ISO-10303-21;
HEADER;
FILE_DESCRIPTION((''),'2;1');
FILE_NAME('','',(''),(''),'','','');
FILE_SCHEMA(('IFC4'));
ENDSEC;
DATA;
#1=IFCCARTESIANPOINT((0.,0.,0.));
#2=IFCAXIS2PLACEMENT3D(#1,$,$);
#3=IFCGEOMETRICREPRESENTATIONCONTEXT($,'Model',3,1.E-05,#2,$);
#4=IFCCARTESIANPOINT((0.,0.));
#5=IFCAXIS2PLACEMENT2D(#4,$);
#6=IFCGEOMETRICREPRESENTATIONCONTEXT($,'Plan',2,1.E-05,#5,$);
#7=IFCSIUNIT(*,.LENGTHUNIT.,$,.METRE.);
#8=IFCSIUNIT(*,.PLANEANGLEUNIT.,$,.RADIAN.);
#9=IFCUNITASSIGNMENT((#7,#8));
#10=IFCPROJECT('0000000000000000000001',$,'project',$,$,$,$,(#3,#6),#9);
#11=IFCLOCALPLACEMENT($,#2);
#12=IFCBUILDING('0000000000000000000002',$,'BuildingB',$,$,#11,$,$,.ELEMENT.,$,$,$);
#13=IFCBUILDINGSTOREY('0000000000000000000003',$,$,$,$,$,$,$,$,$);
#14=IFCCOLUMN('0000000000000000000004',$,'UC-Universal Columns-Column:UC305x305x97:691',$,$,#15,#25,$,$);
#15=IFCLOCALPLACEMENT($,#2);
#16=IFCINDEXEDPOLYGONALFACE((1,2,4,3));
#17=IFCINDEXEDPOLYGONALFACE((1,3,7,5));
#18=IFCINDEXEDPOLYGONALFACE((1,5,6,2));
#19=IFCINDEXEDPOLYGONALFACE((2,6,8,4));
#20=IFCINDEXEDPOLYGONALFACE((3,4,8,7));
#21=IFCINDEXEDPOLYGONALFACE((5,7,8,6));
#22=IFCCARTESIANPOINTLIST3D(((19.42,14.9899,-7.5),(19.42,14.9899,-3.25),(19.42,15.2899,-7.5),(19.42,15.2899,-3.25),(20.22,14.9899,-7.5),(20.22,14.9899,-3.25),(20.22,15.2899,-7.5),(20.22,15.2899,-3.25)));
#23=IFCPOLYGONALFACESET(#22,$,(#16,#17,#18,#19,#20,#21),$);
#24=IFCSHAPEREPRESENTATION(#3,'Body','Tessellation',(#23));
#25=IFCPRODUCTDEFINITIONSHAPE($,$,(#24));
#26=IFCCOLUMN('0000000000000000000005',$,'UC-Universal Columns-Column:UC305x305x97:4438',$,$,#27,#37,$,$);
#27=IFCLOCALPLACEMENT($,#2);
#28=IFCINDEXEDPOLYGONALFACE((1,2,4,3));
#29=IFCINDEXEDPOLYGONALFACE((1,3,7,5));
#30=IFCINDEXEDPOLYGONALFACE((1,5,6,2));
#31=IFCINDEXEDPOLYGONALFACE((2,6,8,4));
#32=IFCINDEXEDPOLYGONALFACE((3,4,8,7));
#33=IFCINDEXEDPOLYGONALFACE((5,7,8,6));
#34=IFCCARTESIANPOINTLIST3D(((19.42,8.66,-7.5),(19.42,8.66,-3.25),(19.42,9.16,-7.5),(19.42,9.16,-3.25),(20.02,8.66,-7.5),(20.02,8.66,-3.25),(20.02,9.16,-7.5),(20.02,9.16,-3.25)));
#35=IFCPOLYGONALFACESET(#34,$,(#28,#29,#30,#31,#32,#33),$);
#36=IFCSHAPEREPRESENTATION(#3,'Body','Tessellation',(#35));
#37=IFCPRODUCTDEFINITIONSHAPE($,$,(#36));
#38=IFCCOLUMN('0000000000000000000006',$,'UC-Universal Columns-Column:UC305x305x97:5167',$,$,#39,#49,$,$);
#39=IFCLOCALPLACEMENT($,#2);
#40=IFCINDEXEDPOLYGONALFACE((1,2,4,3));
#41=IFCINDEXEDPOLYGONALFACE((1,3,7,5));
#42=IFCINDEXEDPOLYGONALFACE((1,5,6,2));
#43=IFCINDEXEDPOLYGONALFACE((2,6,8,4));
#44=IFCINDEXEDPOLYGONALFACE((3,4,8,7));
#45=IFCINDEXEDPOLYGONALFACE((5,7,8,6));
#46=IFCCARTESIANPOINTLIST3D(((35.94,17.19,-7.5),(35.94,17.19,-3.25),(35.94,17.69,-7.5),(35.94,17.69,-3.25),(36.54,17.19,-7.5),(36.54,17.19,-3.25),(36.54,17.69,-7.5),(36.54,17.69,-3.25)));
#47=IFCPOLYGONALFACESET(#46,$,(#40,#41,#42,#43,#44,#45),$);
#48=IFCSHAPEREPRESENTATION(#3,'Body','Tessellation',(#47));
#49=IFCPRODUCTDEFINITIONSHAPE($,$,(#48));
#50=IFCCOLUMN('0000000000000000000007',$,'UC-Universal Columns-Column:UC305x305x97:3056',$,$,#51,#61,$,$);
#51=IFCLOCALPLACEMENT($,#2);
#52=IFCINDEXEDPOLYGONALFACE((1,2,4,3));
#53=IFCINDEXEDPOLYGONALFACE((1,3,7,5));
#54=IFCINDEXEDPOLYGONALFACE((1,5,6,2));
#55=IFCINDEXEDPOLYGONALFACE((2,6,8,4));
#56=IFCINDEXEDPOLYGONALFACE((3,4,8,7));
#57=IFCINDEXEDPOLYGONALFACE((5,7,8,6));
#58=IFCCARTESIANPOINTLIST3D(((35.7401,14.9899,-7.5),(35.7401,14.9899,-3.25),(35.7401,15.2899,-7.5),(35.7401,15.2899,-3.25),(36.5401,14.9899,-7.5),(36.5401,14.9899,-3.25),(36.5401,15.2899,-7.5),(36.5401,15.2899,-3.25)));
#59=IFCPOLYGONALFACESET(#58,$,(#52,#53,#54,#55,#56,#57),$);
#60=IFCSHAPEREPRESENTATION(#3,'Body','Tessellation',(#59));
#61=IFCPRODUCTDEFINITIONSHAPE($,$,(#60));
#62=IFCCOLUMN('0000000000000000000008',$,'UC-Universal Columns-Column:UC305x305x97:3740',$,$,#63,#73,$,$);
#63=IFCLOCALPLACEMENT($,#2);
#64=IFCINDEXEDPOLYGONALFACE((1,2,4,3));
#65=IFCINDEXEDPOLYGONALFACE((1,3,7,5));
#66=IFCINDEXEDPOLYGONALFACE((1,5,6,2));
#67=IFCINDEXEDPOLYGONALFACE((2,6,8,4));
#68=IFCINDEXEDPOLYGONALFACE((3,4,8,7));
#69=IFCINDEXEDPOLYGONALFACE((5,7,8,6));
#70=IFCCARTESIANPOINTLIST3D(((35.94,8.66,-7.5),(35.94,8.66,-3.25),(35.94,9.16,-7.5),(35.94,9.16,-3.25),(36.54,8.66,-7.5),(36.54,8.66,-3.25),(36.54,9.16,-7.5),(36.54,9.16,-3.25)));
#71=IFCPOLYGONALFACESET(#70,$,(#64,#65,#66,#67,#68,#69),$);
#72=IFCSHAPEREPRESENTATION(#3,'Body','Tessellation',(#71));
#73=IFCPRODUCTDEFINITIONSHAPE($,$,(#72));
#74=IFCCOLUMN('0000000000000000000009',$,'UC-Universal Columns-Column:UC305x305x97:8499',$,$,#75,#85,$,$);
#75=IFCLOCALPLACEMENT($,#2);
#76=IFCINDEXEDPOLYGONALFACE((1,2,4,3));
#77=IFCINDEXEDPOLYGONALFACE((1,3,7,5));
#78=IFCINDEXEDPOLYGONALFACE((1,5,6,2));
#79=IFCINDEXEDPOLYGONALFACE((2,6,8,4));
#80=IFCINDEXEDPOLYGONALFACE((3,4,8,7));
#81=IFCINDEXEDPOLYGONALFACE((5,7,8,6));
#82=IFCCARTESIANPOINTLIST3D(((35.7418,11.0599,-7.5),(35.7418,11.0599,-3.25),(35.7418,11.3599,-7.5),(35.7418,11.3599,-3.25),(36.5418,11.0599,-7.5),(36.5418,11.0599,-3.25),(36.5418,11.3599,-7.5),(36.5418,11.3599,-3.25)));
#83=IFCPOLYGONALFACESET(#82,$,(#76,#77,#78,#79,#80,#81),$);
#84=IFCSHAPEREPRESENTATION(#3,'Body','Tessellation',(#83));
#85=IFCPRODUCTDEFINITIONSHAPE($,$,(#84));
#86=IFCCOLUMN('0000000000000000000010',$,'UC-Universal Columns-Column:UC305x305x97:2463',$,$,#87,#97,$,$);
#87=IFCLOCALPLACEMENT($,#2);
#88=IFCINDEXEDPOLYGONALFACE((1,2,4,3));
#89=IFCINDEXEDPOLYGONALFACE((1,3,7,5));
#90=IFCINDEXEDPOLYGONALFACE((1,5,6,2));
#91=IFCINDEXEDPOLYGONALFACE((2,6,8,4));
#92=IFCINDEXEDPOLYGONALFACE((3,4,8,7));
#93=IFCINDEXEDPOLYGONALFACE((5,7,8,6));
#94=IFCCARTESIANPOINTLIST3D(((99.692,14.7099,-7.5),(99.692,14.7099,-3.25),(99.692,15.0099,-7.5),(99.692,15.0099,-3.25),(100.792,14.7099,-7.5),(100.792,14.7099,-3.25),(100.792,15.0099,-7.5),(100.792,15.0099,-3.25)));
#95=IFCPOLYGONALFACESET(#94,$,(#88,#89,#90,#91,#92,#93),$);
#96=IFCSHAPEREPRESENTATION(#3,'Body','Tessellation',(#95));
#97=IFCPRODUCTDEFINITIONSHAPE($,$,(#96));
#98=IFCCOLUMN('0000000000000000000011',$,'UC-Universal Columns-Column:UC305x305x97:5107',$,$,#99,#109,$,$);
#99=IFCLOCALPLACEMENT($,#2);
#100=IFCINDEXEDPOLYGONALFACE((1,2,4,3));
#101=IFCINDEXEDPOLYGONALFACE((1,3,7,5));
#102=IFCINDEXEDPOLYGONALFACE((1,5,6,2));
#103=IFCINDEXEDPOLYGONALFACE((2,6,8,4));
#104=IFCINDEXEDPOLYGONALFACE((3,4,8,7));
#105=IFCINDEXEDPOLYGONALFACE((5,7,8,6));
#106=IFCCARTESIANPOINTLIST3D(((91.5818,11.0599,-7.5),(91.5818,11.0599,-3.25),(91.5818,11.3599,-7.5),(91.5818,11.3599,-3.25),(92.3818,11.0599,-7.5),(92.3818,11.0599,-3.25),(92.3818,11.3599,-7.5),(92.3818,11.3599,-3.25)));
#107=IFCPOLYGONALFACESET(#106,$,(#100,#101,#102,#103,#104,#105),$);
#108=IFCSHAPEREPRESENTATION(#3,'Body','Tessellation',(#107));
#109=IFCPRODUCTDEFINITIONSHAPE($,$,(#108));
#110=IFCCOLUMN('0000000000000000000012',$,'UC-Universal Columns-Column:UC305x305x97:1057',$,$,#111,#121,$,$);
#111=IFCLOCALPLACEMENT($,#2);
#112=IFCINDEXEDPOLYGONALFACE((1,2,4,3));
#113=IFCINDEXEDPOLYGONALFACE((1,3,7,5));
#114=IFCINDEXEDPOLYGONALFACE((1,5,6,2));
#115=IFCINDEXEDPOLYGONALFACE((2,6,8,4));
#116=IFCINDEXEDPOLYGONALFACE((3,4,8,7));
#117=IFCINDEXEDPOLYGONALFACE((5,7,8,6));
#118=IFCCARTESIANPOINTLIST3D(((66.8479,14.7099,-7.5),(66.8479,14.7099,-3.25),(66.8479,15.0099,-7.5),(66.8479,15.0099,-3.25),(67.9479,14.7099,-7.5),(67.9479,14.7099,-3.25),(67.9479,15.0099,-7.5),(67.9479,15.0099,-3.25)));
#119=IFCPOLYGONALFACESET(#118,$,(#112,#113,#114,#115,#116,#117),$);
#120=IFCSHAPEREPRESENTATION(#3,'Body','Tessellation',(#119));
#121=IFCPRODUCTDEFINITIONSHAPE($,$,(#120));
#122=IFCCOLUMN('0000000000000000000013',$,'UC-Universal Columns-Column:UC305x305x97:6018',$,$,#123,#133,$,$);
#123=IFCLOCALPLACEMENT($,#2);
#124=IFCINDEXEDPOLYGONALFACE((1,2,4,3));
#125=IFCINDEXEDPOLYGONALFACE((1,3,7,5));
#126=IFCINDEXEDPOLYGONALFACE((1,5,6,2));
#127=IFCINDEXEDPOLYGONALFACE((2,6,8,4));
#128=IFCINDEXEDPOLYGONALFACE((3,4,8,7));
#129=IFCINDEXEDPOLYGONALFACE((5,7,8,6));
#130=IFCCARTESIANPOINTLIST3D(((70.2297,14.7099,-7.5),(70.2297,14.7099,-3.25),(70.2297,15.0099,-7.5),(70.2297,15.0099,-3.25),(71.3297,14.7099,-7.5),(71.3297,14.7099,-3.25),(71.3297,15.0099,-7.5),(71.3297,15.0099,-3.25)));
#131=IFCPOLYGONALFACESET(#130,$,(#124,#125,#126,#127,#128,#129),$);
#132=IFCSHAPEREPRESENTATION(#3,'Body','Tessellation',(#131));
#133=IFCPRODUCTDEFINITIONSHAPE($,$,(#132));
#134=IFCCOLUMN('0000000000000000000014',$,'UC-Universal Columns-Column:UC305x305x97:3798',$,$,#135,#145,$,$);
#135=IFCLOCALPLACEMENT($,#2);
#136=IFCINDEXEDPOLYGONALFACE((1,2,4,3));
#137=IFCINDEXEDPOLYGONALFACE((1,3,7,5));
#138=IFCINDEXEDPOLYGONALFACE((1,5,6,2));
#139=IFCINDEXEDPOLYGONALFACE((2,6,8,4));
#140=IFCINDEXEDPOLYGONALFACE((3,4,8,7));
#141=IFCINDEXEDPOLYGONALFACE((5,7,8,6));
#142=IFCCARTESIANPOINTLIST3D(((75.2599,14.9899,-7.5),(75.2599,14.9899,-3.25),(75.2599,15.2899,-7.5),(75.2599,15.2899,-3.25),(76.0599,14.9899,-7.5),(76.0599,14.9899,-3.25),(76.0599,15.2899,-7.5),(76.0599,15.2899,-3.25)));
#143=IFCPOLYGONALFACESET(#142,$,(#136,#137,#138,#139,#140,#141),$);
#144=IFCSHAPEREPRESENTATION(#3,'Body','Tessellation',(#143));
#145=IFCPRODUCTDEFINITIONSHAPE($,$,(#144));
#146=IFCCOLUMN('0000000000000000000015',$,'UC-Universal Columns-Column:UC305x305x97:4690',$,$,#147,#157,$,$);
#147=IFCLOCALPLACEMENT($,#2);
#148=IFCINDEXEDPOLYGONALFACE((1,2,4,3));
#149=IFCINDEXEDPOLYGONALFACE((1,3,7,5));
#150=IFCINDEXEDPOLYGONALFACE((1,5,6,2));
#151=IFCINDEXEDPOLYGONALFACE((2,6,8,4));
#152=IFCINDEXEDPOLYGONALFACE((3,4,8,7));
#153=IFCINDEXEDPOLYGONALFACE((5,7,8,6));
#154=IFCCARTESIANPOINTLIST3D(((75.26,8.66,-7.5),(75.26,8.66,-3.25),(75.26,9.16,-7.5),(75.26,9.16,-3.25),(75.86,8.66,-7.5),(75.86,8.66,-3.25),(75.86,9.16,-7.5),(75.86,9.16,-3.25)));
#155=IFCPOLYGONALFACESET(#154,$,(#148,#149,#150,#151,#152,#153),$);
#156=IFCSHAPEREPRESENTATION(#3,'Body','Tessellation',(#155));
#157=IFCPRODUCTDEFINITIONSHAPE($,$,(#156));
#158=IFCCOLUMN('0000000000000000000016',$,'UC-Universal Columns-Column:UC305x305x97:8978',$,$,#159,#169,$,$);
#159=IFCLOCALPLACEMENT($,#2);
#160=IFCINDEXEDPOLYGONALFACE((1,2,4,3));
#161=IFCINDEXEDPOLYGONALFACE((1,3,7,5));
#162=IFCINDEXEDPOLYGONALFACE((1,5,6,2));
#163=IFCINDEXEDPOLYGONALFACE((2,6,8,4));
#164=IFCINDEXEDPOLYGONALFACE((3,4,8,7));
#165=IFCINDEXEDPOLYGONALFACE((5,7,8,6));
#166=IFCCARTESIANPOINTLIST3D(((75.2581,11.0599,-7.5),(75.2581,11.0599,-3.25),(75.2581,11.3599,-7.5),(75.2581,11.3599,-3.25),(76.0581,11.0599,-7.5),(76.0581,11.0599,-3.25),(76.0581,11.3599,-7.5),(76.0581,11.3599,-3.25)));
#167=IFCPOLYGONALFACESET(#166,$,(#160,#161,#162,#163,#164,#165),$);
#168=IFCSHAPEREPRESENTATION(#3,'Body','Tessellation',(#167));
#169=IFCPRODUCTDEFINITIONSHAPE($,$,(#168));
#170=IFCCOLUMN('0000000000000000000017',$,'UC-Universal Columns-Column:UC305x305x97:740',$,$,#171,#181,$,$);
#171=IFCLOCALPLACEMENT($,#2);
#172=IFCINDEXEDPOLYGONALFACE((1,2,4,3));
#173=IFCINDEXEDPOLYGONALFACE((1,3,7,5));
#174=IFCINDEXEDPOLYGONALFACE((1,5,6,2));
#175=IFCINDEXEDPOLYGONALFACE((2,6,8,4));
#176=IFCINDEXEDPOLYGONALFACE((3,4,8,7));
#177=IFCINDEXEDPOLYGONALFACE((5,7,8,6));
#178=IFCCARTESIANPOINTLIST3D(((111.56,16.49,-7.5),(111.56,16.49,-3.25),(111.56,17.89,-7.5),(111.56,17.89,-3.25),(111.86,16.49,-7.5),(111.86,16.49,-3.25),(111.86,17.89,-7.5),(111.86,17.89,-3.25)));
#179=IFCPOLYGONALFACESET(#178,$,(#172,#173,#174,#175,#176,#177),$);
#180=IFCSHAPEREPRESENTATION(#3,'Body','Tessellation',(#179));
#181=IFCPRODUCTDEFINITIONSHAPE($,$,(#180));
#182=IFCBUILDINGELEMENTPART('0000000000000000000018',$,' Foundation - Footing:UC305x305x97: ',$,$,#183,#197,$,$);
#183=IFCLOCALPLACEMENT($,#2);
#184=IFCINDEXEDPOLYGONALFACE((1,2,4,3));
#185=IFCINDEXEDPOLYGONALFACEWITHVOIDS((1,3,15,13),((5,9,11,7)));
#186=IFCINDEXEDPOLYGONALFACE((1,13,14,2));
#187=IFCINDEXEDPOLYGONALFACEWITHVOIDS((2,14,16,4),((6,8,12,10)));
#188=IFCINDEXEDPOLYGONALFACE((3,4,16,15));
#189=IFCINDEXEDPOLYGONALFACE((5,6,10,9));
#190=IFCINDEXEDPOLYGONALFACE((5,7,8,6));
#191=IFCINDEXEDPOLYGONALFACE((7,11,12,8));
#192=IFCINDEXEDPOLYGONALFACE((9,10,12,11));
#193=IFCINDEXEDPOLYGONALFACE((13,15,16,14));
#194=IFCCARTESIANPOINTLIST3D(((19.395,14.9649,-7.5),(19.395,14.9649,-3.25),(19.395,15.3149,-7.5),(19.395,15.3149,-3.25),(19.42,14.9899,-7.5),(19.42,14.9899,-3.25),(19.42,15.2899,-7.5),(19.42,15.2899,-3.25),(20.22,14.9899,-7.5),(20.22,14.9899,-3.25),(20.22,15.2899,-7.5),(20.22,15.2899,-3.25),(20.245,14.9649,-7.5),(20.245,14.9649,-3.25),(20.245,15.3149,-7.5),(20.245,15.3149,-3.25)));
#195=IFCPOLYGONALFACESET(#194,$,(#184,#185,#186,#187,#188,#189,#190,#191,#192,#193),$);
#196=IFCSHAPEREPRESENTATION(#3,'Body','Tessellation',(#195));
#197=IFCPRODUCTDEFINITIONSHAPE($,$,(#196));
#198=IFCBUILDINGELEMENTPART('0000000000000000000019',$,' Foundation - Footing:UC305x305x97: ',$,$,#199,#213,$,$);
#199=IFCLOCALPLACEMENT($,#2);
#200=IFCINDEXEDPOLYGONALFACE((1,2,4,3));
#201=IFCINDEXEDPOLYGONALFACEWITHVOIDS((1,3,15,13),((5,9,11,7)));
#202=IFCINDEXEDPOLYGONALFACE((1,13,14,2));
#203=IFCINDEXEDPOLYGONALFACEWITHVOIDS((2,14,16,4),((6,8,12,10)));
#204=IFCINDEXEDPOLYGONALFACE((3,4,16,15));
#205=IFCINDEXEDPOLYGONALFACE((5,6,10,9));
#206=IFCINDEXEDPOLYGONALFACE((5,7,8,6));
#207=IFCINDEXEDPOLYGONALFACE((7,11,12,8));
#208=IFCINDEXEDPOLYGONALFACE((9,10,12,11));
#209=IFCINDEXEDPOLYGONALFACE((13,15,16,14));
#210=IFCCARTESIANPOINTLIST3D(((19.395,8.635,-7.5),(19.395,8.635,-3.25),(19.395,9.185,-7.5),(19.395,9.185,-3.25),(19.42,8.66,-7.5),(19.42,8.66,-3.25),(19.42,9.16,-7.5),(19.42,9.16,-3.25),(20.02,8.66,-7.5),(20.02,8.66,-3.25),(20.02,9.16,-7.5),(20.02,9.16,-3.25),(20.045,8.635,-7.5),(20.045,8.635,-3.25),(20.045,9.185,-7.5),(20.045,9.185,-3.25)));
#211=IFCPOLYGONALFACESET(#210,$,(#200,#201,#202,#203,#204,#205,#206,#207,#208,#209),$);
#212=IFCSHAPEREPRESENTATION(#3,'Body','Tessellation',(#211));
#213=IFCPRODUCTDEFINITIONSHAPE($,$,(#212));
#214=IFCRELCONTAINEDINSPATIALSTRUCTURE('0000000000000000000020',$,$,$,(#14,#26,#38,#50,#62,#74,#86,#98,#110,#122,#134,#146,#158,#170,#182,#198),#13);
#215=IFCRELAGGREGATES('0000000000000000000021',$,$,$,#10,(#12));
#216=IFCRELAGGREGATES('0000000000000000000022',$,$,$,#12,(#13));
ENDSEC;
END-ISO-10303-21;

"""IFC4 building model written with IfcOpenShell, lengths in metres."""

from ifc_helpers import new_model, si_unit, origin, origin_2d, place, context, project, spatial, polyline, outline, extrude, element, save


model = new_model("IFC4")

# Units and contexts
model_context = context("Model", 3, precision=1e-05, world=origin())
plan_context = context("Plan", 2, precision=1e-05, world=origin_2d())
ifc_project = project(units=[si_unit("LENGTHUNIT", "METRE"), si_unit("PLANEANGLEUNIT", "RADIAN")], contexts=[model_context, plan_context])

# Building, storey
building_placement = place(None, origin())
building = spatial("IfcBuilding", under=ifc_project, at=building_placement, Name="BuildingB", CompositionType="ELEMENT")
storey = spatial("IfcBuildingStorey", under=building)

# Columns
element("IfcColumn", 1, inside=storey, Name="UC-Universal Columns-Column:UC305x305x97:691", context=model_context, shape_type="SweptSolid", body=[
    extrude(outline(polyline([(19.42, 15.2899, -7.5), (20.22, 15.2899, -7.5), (20.22, 14.9899, -7.5), (19.42, 14.9899, -7.5), (19.42, 15.2899, -7.5)])), None, (0.0, 0.0, 1.0), 4.25),
])
element("IfcColumn", 2, inside=storey, Name="UC-Universal Columns-Column:UC305x305x97:4438", context=model_context, shape_type="SweptSolid", body=[
    extrude(outline(polyline([(19.42, 8.66, -7.5), (20.02, 8.66, -7.5), (20.02, 9.16, -7.5), (19.42, 9.16, -7.5), (19.42, 8.66, -7.5)])), None, (0.0, 0.0, 1.0), 4.25),
])
element("IfcColumn", 3, inside=storey, Name="UC-Universal Columns-Column:UC305x305x97:5167", context=model_context, shape_type="SweptSolid", body=[
    extrude(outline(polyline([(36.54, 17.69, -7.5), (35.94, 17.69, -7.5), (35.94, 17.19, -7.5), (36.54, 17.19, -7.5), (36.54, 17.69, -7.5)])), None, (0.0, 0.0, 1.0), 4.25),
])
element("IfcColumn", 4, inside=storey, Name="UC-Universal Columns-Column:UC305x305x97:3056", context=model_context, shape_type="SweptSolid", body=[
    extrude(outline(polyline([(36.5401, 15.2899, -7.5), (35.7401, 15.2899, -7.5), (35.7401, 14.9899, -7.5), (36.5401, 14.9899, -7.5), (36.5401, 15.2899, -7.5)])), None, (0.0, 0.0, 1.0), 4.25),
])
element("IfcColumn", 5, inside=storey, Name="UC-Universal Columns-Column:UC305x305x97:3740", context=model_context, shape_type="SweptSolid", body=[
    extrude(outline(polyline([(36.54, 8.66, -7.5), (35.94, 8.66, -7.5), (35.94, 9.16, -7.5), (36.54, 9.16, -7.5), (36.54, 8.66, -7.5)])), None, (0.0, 0.0, 1.0), 4.25),
])
element("IfcColumn", 6, inside=storey, Name="UC-Universal Columns-Column:UC305x305x97:8499", context=model_context, shape_type="SweptSolid", body=[
    extrude(outline(polyline([(36.5418, 11.0599, -7.5), (35.7418, 11.0599, -7.5), (35.7418, 11.3599, -7.5), (36.5418, 11.3599, -7.5), (36.5418, 11.0599, -7.5)])), None, (0.0, 0.0, 1.0), 4.25),
])
element("IfcColumn", 7, inside=storey, Name="UC-Universal Columns-Column:UC305x305x97:2463", context=model_context, shape_type="SweptSolid", body=[
    extrude(outline(polyline([(100.792, 14.7099, -7.5), (100.792, 15.0099, -7.5), (99.692, 15.0099, -7.5), (99.692, 14.7099, -7.5), (100.792, 14.7099, -7.5)])), None, (0.0, 0.0, 1.0), 4.25),
])
element("IfcColumn", 8, inside=storey, Name="UC-Universal Columns-Column:UC305x305x97:5107", context=model_context, shape_type="SweptSolid", body=[
    extrude(outline(polyline([(92.3818, 11.0599, -7.5), (91.5818, 11.0599, -7.5), (91.5818, 11.3599, -7.5), (92.3818, 11.3599, -7.5), (92.3818, 11.0599, -7.5)])), None, (0.0, 0.0, 1.0), 4.25),
])
element("IfcColumn", 9, inside=storey, Name="UC-Universal Columns-Column:UC305x305x97:1057", context=model_context, shape_type="SweptSolid", body=[
    extrude(outline(polyline([(66.8479, 14.7099, -7.5), (66.8479, 15.0099, -7.5), (67.9479, 15.0099, -7.5), (67.9479, 14.7099, -7.5), (66.8479, 14.7099, -7.5)])), None, (0.0, 0.0, 1.0), 4.25),
])
element("IfcColumn", 10, inside=storey, Name="UC-Universal Columns-Column:UC305x305x97:6018", context=model_context, shape_type="SweptSolid", body=[
    extrude(outline(polyline([(70.2297, 15.0099, -7.5), (71.3297, 15.0099, -7.5), (71.3297, 14.7099, -7.5), (70.2297, 14.7099, -7.5), (70.2297, 15.0099, -7.5)])), None, (0.0, 0.0, 1.0), 4.25),
])
element("IfcColumn", 11, inside=storey, Name="UC-Universal Columns-Column:UC305x305x97:3798", context=model_context, shape_type="SweptSolid", body=[
    extrude(outline(polyline([(75.2599, 15.2899, -7.5), (76.0599, 15.2899, -7.5), (76.0599, 14.9899, -7.5), (75.2599, 14.9899, -7.5), (75.2599, 15.2899, -7.5)])), None, (0.0, 0.0, 1.0), 4.25),
])
element("IfcColumn", 12, inside=storey, Name="UC-Universal Columns-Column:UC305x305x97:4690", context=model_context, shape_type="SweptSolid", body=[
    extrude(outline(polyline([(75.26, 8.66, -7.5), (75.86, 8.66, -7.5), (75.86, 9.16, -7.5), (75.26, 9.16, -7.5), (75.26, 8.66, -7.5)])), None, (0.0, 0.0, 1.0), 4.25),
])
element("IfcColumn", 13, inside=storey, Name="UC-Universal Columns-Column:UC305x305x97:8978", context=model_context, shape_type="SweptSolid", body=[
    extrude(outline(polyline([(75.2581, 11.0599, -7.5), (76.0581, 11.0599, -7.5), (76.0581, 11.3599, -7.5), (75.2581, 11.3599, -7.5), (75.2581, 11.0599, -7.5)])), None, (0.0, 0.0, 1.0), 4.25),
])
element("IfcColumn", 14, inside=storey, Name="UC-Universal Columns-Column:UC305x305x97:740", context=model_context, shape_type="SweptSolid", body=[
    extrude(outline(polyline([(111.86, 17.89, -7.5), (111.56, 17.89, -7.5), (111.56, 16.49, -7.5), (111.86, 16.49, -7.5), (111.86, 17.89, -7.5)])), None, (0.0, 0.0, 1.0), 4.25),
])

# Building element parts, openings
building_element_part_1 = element("IfcBuildingElementPart", 15, inside=storey, Name=" Foundation - Footing:UC305x305x97: ", context=model_context, shape_type="SweptSolid", body=[
    extrude(outline(polyline([(19.395, 15.3149, -7.5), (20.245, 15.3149, -7.5), (20.245, 14.9649, -7.5), (19.395, 14.9649, -7.5), (19.395, 15.3149, -7.5)])), None, (0.0, 0.0, 1.0), 4.25),
])
element("IfcOpeningElement", 16, inside=storey, cuts=building_element_part_1, context=model_context, shape_type="SweptSolid", body=[
    extrude(outline(polyline([(19.42, 15.2899, -7.5), (20.22, 15.2899, -7.5), (20.22, 14.9899, -7.5), (19.42, 14.9899, -7.5), (19.42, 15.2899, -7.5)])), None, (0.0, 0.0, 1.0), 4.25),
])
building_element_part_2 = element("IfcBuildingElementPart", 17, inside=storey, Name=" Foundation - Footing:UC305x305x97: ", context=model_context, shape_type="SweptSolid", body=[
    extrude(outline(polyline([(19.395, 8.635, -7.5), (20.045, 8.635, -7.5), (20.045, 9.185, -7.5), (19.395, 9.185, -7.5), (19.395, 8.635, -7.5)])), None, (0.0, 0.0, 1.0), 4.25),
])
element("IfcOpeningElement", 18, inside=storey, cuts=building_element_part_2, context=model_context, shape_type="SweptSolid", body=[
    extrude(outline(polyline([(19.42, 8.66, -7.5), (20.02, 8.66, -7.5), (20.02, 9.16, -7.5), (19.42, 9.16, -7.5), (19.42, 8.66, -7.5)])), None, (0.0, 0.0, 1.0), 4.25),
])

save(model, "model.ifc")
